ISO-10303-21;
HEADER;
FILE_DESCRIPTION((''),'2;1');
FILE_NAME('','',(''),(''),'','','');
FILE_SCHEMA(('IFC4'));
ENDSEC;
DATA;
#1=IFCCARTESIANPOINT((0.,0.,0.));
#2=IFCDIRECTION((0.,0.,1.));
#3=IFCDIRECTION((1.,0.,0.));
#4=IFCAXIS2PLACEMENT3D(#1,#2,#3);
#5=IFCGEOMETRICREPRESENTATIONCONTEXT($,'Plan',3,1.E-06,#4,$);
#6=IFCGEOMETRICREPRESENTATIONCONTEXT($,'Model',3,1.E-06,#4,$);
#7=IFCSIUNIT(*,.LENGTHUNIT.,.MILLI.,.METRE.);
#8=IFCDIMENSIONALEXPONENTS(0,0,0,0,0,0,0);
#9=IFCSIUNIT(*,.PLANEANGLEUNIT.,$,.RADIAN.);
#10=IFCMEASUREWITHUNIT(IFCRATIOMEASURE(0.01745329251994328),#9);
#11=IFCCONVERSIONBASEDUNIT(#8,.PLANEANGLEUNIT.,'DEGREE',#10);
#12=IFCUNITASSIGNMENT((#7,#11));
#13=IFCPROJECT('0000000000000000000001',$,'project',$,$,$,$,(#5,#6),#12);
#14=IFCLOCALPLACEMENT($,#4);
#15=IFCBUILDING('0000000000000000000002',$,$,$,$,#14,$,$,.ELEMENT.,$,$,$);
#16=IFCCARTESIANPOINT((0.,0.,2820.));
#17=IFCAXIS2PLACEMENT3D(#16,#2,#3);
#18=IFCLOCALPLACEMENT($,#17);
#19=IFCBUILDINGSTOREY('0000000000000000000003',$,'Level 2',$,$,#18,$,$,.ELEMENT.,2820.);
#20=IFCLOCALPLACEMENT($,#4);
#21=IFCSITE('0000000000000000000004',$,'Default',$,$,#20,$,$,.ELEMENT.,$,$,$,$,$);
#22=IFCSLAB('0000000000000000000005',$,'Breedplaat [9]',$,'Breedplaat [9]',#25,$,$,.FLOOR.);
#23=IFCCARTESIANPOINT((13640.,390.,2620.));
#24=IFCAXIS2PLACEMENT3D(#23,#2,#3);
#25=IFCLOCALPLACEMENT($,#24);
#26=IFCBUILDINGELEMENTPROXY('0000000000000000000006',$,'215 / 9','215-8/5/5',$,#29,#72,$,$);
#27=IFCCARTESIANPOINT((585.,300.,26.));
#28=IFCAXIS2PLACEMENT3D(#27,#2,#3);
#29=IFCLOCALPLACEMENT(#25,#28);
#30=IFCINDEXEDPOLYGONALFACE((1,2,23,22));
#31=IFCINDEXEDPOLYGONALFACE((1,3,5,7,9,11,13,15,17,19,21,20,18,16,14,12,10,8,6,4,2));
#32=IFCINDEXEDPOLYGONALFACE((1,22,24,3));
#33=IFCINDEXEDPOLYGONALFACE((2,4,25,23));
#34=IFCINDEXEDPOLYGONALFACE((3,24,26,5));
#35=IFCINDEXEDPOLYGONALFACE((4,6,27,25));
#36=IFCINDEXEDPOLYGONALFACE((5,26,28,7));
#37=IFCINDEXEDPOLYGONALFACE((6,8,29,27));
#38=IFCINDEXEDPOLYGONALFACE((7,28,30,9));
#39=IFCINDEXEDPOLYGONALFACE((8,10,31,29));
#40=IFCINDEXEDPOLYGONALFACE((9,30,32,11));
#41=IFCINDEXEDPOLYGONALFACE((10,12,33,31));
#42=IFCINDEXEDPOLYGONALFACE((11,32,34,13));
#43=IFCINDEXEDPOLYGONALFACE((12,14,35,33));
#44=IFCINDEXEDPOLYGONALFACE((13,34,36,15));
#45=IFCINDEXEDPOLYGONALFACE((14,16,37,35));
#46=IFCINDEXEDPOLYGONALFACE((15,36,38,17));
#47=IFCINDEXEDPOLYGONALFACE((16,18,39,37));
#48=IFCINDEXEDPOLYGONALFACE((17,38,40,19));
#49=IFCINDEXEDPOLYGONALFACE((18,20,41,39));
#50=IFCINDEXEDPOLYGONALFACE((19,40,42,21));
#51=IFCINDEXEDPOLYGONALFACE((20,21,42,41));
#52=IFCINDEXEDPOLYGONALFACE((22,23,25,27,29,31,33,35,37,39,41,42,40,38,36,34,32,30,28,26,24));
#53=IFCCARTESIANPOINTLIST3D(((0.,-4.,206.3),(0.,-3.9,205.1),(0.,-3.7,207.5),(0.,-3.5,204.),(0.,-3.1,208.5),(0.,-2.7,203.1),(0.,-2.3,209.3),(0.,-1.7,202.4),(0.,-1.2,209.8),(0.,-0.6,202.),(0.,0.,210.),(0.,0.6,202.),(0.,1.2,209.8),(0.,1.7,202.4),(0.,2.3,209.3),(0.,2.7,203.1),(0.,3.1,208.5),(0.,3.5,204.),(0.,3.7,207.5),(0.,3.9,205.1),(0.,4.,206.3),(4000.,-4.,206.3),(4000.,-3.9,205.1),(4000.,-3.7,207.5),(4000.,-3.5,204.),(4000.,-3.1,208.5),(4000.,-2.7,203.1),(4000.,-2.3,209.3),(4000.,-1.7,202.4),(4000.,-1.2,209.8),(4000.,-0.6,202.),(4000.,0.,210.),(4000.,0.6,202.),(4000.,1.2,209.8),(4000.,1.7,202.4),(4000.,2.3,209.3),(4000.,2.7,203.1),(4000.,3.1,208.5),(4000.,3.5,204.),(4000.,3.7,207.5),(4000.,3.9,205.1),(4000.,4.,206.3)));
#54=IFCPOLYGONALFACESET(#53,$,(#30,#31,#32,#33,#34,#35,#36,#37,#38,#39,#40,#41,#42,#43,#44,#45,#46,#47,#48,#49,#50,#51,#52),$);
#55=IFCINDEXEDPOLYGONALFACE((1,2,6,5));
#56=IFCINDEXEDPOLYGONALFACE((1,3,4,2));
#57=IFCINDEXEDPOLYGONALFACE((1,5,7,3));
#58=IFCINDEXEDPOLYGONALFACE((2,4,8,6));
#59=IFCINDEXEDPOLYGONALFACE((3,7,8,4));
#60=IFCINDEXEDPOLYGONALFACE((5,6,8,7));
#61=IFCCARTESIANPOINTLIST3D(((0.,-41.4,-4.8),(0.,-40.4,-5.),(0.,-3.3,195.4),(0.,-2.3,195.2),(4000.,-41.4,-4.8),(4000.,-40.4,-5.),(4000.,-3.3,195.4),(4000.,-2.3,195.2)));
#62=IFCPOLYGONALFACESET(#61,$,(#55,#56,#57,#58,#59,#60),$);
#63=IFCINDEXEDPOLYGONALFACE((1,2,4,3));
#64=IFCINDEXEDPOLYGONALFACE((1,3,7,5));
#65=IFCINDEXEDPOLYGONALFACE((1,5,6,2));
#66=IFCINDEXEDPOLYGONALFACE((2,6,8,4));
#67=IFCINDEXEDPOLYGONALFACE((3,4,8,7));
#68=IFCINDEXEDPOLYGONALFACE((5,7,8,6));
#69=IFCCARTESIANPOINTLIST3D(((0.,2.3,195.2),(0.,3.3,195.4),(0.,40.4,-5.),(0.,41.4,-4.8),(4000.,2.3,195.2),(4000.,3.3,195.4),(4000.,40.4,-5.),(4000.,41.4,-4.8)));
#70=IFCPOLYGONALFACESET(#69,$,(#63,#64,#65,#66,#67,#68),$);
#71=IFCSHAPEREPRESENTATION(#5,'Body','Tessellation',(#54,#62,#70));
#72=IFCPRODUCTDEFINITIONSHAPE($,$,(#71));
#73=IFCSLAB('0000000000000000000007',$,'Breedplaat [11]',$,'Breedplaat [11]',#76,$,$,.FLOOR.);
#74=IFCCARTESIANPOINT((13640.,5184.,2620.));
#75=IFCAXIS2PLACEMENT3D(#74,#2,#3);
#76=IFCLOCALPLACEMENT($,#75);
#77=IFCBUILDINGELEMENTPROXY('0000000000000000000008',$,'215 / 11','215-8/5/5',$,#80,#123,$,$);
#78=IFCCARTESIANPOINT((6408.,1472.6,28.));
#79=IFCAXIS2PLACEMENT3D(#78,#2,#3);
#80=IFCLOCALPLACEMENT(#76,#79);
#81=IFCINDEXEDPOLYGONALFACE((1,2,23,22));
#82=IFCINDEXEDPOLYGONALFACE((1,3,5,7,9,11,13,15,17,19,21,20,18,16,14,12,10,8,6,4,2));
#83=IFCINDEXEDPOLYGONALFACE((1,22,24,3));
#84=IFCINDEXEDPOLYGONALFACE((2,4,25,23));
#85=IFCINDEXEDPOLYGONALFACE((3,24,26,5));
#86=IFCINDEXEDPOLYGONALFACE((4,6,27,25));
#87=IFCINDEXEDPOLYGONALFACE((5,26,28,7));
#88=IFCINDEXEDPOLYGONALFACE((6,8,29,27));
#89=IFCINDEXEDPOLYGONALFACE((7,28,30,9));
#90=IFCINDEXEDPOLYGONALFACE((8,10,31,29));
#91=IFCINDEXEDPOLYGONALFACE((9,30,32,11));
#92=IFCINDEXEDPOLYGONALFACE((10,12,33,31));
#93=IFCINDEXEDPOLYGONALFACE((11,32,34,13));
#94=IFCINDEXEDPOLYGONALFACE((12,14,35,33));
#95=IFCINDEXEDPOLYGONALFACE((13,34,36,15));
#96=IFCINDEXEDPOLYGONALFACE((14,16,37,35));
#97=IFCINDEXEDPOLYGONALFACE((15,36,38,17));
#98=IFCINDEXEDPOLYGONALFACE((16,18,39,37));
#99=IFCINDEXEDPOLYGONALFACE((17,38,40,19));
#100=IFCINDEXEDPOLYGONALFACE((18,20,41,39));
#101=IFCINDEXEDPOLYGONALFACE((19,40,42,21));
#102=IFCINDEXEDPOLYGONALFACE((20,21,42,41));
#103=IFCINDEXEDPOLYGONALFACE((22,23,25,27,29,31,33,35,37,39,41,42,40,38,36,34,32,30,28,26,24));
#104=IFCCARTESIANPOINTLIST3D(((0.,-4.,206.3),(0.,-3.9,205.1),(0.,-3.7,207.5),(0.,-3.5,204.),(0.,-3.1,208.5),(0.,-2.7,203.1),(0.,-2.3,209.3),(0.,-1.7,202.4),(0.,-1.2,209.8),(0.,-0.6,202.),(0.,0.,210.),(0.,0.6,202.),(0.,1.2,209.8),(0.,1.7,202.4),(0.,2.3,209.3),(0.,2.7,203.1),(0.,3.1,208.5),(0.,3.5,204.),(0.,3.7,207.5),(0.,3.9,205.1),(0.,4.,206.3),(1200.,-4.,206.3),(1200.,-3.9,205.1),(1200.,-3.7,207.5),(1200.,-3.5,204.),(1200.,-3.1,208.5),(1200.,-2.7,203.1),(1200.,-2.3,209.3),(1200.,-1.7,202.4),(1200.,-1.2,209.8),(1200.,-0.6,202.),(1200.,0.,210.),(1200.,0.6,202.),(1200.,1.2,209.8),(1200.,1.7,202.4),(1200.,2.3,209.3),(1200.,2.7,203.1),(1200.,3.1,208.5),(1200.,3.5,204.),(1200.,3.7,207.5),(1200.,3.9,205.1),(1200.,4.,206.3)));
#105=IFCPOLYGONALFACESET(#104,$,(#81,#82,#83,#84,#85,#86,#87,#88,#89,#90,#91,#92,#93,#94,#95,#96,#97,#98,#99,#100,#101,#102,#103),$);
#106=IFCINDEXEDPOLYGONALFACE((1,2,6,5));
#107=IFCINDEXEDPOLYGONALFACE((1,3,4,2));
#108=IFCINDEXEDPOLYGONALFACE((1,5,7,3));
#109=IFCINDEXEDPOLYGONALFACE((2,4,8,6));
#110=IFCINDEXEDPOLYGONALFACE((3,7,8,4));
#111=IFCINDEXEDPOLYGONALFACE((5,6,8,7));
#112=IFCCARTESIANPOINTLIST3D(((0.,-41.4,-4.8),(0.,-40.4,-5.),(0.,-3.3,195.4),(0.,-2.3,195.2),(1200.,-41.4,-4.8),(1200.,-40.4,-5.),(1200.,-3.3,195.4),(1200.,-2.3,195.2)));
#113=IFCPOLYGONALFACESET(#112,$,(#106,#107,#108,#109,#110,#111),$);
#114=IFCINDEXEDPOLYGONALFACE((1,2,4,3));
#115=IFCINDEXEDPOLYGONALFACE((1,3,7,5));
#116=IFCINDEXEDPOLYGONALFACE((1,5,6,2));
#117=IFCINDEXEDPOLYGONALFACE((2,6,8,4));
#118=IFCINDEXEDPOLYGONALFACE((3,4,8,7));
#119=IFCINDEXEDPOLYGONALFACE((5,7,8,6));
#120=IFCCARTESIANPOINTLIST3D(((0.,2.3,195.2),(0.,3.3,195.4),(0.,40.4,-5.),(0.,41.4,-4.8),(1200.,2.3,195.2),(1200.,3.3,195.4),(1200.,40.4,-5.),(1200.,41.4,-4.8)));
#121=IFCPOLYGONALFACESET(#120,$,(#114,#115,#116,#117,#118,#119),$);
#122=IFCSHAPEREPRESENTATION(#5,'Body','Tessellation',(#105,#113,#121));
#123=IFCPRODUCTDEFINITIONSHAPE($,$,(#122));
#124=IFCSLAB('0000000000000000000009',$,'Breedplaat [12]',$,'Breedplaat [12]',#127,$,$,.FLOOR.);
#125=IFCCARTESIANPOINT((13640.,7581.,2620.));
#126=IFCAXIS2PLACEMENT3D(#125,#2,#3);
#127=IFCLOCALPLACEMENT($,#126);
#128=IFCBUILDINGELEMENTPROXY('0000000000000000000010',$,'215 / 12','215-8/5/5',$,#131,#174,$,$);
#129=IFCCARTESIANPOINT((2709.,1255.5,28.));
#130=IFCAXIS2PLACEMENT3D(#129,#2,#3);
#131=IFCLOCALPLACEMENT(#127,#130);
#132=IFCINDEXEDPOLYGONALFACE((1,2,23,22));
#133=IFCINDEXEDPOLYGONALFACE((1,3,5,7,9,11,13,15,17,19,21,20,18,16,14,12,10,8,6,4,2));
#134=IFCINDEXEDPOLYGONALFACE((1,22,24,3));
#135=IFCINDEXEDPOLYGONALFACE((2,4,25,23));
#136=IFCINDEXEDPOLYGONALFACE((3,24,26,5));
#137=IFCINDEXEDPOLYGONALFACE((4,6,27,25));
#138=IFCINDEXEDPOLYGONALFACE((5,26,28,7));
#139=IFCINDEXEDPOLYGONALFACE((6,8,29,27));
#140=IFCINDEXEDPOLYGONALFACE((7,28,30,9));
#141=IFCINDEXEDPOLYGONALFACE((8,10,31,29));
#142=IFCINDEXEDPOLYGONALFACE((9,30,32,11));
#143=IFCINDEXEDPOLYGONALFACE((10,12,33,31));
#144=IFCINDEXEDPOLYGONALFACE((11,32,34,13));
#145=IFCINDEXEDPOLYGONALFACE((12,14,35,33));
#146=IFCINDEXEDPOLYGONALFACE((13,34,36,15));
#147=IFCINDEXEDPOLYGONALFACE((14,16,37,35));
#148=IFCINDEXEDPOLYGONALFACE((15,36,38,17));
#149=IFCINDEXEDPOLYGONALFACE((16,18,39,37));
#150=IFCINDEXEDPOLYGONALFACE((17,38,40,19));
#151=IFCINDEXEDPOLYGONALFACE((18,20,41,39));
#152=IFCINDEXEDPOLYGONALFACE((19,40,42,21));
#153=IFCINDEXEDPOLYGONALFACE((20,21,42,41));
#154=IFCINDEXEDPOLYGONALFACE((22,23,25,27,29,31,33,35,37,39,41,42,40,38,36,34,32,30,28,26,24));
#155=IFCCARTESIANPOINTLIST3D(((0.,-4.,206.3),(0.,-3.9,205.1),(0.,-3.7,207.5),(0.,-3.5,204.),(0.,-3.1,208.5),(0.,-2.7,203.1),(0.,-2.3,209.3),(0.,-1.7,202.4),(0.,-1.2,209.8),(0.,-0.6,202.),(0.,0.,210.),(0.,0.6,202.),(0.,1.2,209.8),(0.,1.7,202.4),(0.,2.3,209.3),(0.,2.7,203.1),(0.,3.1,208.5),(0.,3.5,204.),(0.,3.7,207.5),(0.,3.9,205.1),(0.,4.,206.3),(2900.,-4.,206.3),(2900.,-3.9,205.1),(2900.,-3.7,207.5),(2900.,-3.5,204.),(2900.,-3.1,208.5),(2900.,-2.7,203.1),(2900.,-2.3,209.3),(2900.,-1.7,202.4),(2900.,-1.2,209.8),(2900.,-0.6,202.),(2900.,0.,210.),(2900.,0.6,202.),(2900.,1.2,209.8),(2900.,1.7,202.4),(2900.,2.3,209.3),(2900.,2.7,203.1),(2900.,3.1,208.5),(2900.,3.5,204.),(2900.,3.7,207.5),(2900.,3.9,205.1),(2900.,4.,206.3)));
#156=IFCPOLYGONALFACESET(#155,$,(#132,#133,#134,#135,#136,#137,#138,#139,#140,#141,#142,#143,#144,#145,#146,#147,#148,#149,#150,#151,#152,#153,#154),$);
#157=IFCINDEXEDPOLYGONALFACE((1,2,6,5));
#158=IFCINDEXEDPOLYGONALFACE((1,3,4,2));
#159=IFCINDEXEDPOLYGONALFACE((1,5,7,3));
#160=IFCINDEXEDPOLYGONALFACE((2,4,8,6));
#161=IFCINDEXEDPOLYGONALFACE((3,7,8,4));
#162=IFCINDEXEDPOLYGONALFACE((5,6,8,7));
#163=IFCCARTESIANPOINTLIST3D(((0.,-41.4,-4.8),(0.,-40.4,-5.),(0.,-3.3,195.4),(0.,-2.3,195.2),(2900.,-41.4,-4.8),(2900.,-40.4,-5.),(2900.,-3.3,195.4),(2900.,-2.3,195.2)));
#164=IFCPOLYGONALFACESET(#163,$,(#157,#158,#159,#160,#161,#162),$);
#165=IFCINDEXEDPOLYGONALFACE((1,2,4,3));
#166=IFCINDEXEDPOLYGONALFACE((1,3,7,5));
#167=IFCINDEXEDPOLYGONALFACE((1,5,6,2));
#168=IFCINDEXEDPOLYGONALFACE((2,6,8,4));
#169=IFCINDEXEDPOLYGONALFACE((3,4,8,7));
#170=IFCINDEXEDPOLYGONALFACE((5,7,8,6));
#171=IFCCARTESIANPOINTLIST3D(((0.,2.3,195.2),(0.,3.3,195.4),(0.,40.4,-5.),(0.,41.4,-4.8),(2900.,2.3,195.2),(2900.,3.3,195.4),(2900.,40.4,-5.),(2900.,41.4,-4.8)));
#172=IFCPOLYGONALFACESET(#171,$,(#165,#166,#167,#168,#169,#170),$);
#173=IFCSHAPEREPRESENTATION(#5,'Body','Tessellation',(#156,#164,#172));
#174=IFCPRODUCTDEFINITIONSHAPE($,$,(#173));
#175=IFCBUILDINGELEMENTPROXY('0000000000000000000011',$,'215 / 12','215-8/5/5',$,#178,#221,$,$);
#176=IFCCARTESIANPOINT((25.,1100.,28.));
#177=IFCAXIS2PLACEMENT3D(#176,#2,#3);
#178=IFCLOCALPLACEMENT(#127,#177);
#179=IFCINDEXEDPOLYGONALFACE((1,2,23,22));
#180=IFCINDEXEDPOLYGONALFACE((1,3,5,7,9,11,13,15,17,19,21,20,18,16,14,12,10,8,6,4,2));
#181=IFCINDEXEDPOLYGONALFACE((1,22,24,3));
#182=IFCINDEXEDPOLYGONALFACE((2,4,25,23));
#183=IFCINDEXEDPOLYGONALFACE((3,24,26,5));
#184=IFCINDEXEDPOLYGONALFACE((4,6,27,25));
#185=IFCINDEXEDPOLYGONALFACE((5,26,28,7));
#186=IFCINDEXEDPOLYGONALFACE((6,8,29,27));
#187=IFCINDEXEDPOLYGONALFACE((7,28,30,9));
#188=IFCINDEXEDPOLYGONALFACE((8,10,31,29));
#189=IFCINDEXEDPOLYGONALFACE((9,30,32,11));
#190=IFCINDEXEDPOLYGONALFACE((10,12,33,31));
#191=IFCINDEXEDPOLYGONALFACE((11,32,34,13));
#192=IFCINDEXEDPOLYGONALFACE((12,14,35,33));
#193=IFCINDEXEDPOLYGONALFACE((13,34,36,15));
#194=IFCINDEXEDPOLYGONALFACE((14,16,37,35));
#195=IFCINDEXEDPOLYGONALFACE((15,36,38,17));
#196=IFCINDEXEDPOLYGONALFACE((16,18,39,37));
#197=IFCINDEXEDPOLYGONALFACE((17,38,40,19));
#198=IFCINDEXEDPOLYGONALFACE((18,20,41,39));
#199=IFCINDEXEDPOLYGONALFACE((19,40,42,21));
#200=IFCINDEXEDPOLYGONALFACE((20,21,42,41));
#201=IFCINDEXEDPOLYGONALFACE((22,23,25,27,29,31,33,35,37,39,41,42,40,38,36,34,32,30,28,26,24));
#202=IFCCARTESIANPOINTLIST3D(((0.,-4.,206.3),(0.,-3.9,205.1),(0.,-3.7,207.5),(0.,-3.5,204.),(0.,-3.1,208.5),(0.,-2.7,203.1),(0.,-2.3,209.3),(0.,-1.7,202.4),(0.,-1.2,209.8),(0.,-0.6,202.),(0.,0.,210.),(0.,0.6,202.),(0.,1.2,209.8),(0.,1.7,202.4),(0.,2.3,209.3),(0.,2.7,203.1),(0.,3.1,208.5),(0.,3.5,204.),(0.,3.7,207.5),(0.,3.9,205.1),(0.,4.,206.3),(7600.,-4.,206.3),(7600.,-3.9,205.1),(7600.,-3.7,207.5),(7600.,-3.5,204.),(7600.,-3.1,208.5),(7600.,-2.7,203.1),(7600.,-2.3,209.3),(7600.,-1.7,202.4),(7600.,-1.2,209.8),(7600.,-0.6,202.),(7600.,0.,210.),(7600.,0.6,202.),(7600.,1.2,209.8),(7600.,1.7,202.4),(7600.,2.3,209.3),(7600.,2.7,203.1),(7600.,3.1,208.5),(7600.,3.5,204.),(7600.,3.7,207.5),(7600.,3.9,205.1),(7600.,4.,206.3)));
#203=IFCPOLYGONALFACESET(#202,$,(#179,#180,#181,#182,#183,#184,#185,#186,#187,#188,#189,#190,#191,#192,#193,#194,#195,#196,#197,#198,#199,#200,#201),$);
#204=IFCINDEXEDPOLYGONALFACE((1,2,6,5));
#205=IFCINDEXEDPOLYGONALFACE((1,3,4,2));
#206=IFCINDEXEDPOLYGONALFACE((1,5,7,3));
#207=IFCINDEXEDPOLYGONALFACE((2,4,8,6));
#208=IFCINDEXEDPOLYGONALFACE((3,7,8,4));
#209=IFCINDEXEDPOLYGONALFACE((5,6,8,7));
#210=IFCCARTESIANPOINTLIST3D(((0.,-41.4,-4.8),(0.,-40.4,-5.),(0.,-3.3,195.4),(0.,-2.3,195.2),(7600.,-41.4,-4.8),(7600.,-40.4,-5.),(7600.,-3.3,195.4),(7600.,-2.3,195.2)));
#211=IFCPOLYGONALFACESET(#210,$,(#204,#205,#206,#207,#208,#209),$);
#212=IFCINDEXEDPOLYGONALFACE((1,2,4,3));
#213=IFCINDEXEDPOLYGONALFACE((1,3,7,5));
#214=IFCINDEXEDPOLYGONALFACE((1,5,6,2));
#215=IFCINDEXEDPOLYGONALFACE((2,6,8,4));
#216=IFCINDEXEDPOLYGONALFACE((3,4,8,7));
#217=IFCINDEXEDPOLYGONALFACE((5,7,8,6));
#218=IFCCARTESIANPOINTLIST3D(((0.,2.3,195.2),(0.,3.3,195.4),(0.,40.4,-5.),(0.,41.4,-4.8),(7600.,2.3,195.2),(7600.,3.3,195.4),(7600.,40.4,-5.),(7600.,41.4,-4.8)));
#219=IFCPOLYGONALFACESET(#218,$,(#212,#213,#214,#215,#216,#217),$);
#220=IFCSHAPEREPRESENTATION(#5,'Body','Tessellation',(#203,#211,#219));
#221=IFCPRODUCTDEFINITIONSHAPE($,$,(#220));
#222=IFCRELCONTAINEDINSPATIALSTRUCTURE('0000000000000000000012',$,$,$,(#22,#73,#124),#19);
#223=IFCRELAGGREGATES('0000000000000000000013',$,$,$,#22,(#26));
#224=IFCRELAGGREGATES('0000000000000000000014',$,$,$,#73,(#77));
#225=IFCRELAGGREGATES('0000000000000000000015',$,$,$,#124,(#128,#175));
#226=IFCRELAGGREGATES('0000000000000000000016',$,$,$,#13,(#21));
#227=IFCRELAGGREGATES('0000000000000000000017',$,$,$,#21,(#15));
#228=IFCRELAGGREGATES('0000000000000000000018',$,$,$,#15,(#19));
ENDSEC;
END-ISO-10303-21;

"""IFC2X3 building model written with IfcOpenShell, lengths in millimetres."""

from ifc_helpers import new_model, entity, si_unit, converted_unit, frame, origin_with_axes, origin_2d_with_axis, place, context, project, spatial, rectangle, circle, extrude, element, aggregate, save


model = new_model("IFC2X3")

# Units and contexts
plan_context = context("Plan", 3, precision=1e-06, world=origin_with_axes())
model_context = context("Model", 3, precision=1e-06, world=origin_with_axes())
ifc_project = project(units=[si_unit("LENGTHUNIT", "METRE", prefix="MILLI"), converted_unit("PLANEANGLEUNIT", "DEGREE", entity("IfcRatioMeasure", 0.01745329251994328), si_unit("PLANEANGLEUNIT", "RADIAN"), dimensions=[0, 0, 0, 0, 0, 0, 0])], contexts=[plan_context, model_context])

# Site, building, storey
site_placement = place(None, origin_with_axes())
site = spatial("IfcSite", under=ifc_project, at=site_placement, Name="Default", CompositionType="ELEMENT")
building_placement = place(None, origin_with_axes())
building = spatial("IfcBuilding", under=site, at=building_placement, CompositionType="ELEMENT")
storey_placement = place(None, frame((0.0, 0.0, 2820.0), z_axis=(0.0, 0.0, 1.0), x_axis=(1.0, 0.0, 0.0)))
storey = spatial("IfcBuildingStorey", under=building, at=storey_placement, Name="Level 2", CompositionType="ELEMENT", Elevation=2820.0)

# Slabs, building element proxies
slab_1_placement = place(None, frame((13640.0, 390.0, 2620.0), z_axis=(0.0, 0.0, 1.0), x_axis=(1.0, 0.0, 0.0)))
slab_1 = element("IfcSlab", 1, at=slab_1_placement, inside=storey, Name="Breedplaat [9]", ObjectType="Breedplaat [9]", PredefinedType="FLOOR")
proxy_1_placement = place(slab_1_placement, frame((585.0, 300.0, 26.0), z_axis=(0.0, 0.0, 1.0), x_axis=(1.0, 0.0, 0.0)))
proxy_1 = element("IfcBuildingElementProxy", 2, at=proxy_1_placement, Name="215 / 9", Description="215-8/5/5", context=plan_context, shape_type="SweptSolid", body=[
    extrude(circle(Radius=4.0, at=origin_2d_with_axis()), frame((0.0, 0.0, 206.0), z_axis=(1.0, 0.0, 0.0), x_axis=(0.0, 0.0, 1.0)), (0.0, 0.0, 1.0), 4000.0),
    extrude(rectangle(XDim=203.8, YDim=1.0, at=origin_2d_with_axis()), frame((0.0, -21.9, 95.2), z_axis=(1.0, 0.0, 0.0), x_axis=(0.0, 0.187112, 0.982339)), (0.0, 0.0, 1.0), 4000.0),
    extrude(rectangle(XDim=203.8, YDim=1.0, at=origin_2d_with_axis()), frame((0.0, 21.9, 95.2), z_axis=(1.0, 0.0, 0.0), x_axis=(0.0, -0.187112, 0.982339)), (0.0, 0.0, 1.0), 4000.0),
])
aggregate(slab_1, [proxy_1])
slab_2_placement = place(None, frame((13640.0, 5184.0, 2620.0), z_axis=(0.0, 0.0, 1.0), x_axis=(1.0, 0.0, 0.0)))
slab_2 = element("IfcSlab", 3, at=slab_2_placement, inside=storey, Name="Breedplaat [11]", ObjectType="Breedplaat [11]", PredefinedType="FLOOR")
proxy_2_placement = place(slab_2_placement, frame((6408.0, 1472.6, 28.0), z_axis=(0.0, 0.0, 1.0), x_axis=(1.0, 0.0, 0.0)))
proxy_2 = element("IfcBuildingElementProxy", 4, at=proxy_2_placement, Name="215 / 11", Description="215-8/5/5", context=plan_context, shape_type="SweptSolid", body=[
    extrude(circle(Radius=4.0, at=origin_2d_with_axis()), frame((0.0, 0.0, 206.0), z_axis=(1.0, 0.0, 0.0), x_axis=(0.0, 0.0, 1.0)), (0.0, 0.0, 1.0), 1200.0),
    extrude(rectangle(XDim=203.8, YDim=1.0, at=origin_2d_with_axis()), frame((0.0, -21.9, 95.2), z_axis=(1.0, 0.0, 0.0), x_axis=(0.0, 0.187112, 0.982339)), (0.0, 0.0, 1.0), 1200.0),
    extrude(rectangle(XDim=203.8, YDim=1.0, at=origin_2d_with_axis()), frame((0.0, 21.9, 95.2), z_axis=(1.0, 0.0, 0.0), x_axis=(0.0, -0.187112, 0.982339)), (0.0, 0.0, 1.0), 1200.0),
])
aggregate(slab_2, [proxy_2])
slab_3_placement = place(None, frame((13640.0, 7581.0, 2620.0), z_axis=(0.0, 0.0, 1.0), x_axis=(1.0, 0.0, 0.0)))
slab_3 = element("IfcSlab", 5, at=slab_3_placement, inside=storey, Name="Breedplaat [12]", ObjectType="Breedplaat [12]", PredefinedType="FLOOR")
proxy_3_placement = place(slab_3_placement, frame((2709.0, 1255.5, 28.0), z_axis=(0.0, 0.0, 1.0), x_axis=(1.0, 0.0, 0.0)))
proxy_3 = element("IfcBuildingElementProxy", 6, at=proxy_3_placement, Name="215 / 12", Description="215-8/5/5", context=plan_context, shape_type="SweptSolid", body=[
    extrude(circle(Radius=4.0, at=origin_2d_with_axis()), frame((0.0, 0.0, 206.0), z_axis=(1.0, 0.0, 0.0), x_axis=(0.0, 0.0, 1.0)), (0.0, 0.0, 1.0), 2900.0),
    extrude(rectangle(XDim=203.8, YDim=1.0, at=origin_2d_with_axis()), frame((0.0, -21.9, 95.2), z_axis=(1.0, 0.0, 0.0), x_axis=(0.0, 0.187112, 0.982339)), (0.0, 0.0, 1.0), 2900.0),
    extrude(rectangle(XDim=203.8, YDim=1.0, at=origin_2d_with_axis()), frame((0.0, 21.9, 95.2), z_axis=(1.0, 0.0, 0.0), x_axis=(0.0, -0.187112, 0.982339)), (0.0, 0.0, 1.0), 2900.0),
])
proxy_4_placement = place(slab_3_placement, frame((25.0, 1100.0, 28.0), z_axis=(0.0, 0.0, 1.0), x_axis=(1.0, 0.0, 0.0)))
proxy_4 = element("IfcBuildingElementProxy", 7, at=proxy_4_placement, Name="215 / 12", Description="215-8/5/5", context=plan_context, shape_type="SweptSolid", body=[
    extrude(circle(Radius=4.0, at=origin_2d_with_axis()), frame((0.0, 0.0, 206.0), z_axis=(1.0, 0.0, 0.0), x_axis=(0.0, 0.0, 1.0)), (0.0, 0.0, 1.0), 7600.0),
    extrude(rectangle(XDim=203.8, YDim=1.0, at=origin_2d_with_axis()), frame((0.0, -21.9, 95.2), z_axis=(1.0, 0.0, 0.0), x_axis=(0.0, 0.187112, 0.982339)), (0.0, 0.0, 1.0), 7600.0),
    extrude(rectangle(XDim=203.8, YDim=1.0, at=origin_2d_with_axis()), frame((0.0, 21.9, 95.2), z_axis=(1.0, 0.0, 0.0), x_axis=(0.0, -0.187112, 0.982339)), (0.0, 0.0, 1.0), 7600.0),
])
aggregate(slab_3, [proxy_3, proxy_4])

save(model, "model.ifc")
